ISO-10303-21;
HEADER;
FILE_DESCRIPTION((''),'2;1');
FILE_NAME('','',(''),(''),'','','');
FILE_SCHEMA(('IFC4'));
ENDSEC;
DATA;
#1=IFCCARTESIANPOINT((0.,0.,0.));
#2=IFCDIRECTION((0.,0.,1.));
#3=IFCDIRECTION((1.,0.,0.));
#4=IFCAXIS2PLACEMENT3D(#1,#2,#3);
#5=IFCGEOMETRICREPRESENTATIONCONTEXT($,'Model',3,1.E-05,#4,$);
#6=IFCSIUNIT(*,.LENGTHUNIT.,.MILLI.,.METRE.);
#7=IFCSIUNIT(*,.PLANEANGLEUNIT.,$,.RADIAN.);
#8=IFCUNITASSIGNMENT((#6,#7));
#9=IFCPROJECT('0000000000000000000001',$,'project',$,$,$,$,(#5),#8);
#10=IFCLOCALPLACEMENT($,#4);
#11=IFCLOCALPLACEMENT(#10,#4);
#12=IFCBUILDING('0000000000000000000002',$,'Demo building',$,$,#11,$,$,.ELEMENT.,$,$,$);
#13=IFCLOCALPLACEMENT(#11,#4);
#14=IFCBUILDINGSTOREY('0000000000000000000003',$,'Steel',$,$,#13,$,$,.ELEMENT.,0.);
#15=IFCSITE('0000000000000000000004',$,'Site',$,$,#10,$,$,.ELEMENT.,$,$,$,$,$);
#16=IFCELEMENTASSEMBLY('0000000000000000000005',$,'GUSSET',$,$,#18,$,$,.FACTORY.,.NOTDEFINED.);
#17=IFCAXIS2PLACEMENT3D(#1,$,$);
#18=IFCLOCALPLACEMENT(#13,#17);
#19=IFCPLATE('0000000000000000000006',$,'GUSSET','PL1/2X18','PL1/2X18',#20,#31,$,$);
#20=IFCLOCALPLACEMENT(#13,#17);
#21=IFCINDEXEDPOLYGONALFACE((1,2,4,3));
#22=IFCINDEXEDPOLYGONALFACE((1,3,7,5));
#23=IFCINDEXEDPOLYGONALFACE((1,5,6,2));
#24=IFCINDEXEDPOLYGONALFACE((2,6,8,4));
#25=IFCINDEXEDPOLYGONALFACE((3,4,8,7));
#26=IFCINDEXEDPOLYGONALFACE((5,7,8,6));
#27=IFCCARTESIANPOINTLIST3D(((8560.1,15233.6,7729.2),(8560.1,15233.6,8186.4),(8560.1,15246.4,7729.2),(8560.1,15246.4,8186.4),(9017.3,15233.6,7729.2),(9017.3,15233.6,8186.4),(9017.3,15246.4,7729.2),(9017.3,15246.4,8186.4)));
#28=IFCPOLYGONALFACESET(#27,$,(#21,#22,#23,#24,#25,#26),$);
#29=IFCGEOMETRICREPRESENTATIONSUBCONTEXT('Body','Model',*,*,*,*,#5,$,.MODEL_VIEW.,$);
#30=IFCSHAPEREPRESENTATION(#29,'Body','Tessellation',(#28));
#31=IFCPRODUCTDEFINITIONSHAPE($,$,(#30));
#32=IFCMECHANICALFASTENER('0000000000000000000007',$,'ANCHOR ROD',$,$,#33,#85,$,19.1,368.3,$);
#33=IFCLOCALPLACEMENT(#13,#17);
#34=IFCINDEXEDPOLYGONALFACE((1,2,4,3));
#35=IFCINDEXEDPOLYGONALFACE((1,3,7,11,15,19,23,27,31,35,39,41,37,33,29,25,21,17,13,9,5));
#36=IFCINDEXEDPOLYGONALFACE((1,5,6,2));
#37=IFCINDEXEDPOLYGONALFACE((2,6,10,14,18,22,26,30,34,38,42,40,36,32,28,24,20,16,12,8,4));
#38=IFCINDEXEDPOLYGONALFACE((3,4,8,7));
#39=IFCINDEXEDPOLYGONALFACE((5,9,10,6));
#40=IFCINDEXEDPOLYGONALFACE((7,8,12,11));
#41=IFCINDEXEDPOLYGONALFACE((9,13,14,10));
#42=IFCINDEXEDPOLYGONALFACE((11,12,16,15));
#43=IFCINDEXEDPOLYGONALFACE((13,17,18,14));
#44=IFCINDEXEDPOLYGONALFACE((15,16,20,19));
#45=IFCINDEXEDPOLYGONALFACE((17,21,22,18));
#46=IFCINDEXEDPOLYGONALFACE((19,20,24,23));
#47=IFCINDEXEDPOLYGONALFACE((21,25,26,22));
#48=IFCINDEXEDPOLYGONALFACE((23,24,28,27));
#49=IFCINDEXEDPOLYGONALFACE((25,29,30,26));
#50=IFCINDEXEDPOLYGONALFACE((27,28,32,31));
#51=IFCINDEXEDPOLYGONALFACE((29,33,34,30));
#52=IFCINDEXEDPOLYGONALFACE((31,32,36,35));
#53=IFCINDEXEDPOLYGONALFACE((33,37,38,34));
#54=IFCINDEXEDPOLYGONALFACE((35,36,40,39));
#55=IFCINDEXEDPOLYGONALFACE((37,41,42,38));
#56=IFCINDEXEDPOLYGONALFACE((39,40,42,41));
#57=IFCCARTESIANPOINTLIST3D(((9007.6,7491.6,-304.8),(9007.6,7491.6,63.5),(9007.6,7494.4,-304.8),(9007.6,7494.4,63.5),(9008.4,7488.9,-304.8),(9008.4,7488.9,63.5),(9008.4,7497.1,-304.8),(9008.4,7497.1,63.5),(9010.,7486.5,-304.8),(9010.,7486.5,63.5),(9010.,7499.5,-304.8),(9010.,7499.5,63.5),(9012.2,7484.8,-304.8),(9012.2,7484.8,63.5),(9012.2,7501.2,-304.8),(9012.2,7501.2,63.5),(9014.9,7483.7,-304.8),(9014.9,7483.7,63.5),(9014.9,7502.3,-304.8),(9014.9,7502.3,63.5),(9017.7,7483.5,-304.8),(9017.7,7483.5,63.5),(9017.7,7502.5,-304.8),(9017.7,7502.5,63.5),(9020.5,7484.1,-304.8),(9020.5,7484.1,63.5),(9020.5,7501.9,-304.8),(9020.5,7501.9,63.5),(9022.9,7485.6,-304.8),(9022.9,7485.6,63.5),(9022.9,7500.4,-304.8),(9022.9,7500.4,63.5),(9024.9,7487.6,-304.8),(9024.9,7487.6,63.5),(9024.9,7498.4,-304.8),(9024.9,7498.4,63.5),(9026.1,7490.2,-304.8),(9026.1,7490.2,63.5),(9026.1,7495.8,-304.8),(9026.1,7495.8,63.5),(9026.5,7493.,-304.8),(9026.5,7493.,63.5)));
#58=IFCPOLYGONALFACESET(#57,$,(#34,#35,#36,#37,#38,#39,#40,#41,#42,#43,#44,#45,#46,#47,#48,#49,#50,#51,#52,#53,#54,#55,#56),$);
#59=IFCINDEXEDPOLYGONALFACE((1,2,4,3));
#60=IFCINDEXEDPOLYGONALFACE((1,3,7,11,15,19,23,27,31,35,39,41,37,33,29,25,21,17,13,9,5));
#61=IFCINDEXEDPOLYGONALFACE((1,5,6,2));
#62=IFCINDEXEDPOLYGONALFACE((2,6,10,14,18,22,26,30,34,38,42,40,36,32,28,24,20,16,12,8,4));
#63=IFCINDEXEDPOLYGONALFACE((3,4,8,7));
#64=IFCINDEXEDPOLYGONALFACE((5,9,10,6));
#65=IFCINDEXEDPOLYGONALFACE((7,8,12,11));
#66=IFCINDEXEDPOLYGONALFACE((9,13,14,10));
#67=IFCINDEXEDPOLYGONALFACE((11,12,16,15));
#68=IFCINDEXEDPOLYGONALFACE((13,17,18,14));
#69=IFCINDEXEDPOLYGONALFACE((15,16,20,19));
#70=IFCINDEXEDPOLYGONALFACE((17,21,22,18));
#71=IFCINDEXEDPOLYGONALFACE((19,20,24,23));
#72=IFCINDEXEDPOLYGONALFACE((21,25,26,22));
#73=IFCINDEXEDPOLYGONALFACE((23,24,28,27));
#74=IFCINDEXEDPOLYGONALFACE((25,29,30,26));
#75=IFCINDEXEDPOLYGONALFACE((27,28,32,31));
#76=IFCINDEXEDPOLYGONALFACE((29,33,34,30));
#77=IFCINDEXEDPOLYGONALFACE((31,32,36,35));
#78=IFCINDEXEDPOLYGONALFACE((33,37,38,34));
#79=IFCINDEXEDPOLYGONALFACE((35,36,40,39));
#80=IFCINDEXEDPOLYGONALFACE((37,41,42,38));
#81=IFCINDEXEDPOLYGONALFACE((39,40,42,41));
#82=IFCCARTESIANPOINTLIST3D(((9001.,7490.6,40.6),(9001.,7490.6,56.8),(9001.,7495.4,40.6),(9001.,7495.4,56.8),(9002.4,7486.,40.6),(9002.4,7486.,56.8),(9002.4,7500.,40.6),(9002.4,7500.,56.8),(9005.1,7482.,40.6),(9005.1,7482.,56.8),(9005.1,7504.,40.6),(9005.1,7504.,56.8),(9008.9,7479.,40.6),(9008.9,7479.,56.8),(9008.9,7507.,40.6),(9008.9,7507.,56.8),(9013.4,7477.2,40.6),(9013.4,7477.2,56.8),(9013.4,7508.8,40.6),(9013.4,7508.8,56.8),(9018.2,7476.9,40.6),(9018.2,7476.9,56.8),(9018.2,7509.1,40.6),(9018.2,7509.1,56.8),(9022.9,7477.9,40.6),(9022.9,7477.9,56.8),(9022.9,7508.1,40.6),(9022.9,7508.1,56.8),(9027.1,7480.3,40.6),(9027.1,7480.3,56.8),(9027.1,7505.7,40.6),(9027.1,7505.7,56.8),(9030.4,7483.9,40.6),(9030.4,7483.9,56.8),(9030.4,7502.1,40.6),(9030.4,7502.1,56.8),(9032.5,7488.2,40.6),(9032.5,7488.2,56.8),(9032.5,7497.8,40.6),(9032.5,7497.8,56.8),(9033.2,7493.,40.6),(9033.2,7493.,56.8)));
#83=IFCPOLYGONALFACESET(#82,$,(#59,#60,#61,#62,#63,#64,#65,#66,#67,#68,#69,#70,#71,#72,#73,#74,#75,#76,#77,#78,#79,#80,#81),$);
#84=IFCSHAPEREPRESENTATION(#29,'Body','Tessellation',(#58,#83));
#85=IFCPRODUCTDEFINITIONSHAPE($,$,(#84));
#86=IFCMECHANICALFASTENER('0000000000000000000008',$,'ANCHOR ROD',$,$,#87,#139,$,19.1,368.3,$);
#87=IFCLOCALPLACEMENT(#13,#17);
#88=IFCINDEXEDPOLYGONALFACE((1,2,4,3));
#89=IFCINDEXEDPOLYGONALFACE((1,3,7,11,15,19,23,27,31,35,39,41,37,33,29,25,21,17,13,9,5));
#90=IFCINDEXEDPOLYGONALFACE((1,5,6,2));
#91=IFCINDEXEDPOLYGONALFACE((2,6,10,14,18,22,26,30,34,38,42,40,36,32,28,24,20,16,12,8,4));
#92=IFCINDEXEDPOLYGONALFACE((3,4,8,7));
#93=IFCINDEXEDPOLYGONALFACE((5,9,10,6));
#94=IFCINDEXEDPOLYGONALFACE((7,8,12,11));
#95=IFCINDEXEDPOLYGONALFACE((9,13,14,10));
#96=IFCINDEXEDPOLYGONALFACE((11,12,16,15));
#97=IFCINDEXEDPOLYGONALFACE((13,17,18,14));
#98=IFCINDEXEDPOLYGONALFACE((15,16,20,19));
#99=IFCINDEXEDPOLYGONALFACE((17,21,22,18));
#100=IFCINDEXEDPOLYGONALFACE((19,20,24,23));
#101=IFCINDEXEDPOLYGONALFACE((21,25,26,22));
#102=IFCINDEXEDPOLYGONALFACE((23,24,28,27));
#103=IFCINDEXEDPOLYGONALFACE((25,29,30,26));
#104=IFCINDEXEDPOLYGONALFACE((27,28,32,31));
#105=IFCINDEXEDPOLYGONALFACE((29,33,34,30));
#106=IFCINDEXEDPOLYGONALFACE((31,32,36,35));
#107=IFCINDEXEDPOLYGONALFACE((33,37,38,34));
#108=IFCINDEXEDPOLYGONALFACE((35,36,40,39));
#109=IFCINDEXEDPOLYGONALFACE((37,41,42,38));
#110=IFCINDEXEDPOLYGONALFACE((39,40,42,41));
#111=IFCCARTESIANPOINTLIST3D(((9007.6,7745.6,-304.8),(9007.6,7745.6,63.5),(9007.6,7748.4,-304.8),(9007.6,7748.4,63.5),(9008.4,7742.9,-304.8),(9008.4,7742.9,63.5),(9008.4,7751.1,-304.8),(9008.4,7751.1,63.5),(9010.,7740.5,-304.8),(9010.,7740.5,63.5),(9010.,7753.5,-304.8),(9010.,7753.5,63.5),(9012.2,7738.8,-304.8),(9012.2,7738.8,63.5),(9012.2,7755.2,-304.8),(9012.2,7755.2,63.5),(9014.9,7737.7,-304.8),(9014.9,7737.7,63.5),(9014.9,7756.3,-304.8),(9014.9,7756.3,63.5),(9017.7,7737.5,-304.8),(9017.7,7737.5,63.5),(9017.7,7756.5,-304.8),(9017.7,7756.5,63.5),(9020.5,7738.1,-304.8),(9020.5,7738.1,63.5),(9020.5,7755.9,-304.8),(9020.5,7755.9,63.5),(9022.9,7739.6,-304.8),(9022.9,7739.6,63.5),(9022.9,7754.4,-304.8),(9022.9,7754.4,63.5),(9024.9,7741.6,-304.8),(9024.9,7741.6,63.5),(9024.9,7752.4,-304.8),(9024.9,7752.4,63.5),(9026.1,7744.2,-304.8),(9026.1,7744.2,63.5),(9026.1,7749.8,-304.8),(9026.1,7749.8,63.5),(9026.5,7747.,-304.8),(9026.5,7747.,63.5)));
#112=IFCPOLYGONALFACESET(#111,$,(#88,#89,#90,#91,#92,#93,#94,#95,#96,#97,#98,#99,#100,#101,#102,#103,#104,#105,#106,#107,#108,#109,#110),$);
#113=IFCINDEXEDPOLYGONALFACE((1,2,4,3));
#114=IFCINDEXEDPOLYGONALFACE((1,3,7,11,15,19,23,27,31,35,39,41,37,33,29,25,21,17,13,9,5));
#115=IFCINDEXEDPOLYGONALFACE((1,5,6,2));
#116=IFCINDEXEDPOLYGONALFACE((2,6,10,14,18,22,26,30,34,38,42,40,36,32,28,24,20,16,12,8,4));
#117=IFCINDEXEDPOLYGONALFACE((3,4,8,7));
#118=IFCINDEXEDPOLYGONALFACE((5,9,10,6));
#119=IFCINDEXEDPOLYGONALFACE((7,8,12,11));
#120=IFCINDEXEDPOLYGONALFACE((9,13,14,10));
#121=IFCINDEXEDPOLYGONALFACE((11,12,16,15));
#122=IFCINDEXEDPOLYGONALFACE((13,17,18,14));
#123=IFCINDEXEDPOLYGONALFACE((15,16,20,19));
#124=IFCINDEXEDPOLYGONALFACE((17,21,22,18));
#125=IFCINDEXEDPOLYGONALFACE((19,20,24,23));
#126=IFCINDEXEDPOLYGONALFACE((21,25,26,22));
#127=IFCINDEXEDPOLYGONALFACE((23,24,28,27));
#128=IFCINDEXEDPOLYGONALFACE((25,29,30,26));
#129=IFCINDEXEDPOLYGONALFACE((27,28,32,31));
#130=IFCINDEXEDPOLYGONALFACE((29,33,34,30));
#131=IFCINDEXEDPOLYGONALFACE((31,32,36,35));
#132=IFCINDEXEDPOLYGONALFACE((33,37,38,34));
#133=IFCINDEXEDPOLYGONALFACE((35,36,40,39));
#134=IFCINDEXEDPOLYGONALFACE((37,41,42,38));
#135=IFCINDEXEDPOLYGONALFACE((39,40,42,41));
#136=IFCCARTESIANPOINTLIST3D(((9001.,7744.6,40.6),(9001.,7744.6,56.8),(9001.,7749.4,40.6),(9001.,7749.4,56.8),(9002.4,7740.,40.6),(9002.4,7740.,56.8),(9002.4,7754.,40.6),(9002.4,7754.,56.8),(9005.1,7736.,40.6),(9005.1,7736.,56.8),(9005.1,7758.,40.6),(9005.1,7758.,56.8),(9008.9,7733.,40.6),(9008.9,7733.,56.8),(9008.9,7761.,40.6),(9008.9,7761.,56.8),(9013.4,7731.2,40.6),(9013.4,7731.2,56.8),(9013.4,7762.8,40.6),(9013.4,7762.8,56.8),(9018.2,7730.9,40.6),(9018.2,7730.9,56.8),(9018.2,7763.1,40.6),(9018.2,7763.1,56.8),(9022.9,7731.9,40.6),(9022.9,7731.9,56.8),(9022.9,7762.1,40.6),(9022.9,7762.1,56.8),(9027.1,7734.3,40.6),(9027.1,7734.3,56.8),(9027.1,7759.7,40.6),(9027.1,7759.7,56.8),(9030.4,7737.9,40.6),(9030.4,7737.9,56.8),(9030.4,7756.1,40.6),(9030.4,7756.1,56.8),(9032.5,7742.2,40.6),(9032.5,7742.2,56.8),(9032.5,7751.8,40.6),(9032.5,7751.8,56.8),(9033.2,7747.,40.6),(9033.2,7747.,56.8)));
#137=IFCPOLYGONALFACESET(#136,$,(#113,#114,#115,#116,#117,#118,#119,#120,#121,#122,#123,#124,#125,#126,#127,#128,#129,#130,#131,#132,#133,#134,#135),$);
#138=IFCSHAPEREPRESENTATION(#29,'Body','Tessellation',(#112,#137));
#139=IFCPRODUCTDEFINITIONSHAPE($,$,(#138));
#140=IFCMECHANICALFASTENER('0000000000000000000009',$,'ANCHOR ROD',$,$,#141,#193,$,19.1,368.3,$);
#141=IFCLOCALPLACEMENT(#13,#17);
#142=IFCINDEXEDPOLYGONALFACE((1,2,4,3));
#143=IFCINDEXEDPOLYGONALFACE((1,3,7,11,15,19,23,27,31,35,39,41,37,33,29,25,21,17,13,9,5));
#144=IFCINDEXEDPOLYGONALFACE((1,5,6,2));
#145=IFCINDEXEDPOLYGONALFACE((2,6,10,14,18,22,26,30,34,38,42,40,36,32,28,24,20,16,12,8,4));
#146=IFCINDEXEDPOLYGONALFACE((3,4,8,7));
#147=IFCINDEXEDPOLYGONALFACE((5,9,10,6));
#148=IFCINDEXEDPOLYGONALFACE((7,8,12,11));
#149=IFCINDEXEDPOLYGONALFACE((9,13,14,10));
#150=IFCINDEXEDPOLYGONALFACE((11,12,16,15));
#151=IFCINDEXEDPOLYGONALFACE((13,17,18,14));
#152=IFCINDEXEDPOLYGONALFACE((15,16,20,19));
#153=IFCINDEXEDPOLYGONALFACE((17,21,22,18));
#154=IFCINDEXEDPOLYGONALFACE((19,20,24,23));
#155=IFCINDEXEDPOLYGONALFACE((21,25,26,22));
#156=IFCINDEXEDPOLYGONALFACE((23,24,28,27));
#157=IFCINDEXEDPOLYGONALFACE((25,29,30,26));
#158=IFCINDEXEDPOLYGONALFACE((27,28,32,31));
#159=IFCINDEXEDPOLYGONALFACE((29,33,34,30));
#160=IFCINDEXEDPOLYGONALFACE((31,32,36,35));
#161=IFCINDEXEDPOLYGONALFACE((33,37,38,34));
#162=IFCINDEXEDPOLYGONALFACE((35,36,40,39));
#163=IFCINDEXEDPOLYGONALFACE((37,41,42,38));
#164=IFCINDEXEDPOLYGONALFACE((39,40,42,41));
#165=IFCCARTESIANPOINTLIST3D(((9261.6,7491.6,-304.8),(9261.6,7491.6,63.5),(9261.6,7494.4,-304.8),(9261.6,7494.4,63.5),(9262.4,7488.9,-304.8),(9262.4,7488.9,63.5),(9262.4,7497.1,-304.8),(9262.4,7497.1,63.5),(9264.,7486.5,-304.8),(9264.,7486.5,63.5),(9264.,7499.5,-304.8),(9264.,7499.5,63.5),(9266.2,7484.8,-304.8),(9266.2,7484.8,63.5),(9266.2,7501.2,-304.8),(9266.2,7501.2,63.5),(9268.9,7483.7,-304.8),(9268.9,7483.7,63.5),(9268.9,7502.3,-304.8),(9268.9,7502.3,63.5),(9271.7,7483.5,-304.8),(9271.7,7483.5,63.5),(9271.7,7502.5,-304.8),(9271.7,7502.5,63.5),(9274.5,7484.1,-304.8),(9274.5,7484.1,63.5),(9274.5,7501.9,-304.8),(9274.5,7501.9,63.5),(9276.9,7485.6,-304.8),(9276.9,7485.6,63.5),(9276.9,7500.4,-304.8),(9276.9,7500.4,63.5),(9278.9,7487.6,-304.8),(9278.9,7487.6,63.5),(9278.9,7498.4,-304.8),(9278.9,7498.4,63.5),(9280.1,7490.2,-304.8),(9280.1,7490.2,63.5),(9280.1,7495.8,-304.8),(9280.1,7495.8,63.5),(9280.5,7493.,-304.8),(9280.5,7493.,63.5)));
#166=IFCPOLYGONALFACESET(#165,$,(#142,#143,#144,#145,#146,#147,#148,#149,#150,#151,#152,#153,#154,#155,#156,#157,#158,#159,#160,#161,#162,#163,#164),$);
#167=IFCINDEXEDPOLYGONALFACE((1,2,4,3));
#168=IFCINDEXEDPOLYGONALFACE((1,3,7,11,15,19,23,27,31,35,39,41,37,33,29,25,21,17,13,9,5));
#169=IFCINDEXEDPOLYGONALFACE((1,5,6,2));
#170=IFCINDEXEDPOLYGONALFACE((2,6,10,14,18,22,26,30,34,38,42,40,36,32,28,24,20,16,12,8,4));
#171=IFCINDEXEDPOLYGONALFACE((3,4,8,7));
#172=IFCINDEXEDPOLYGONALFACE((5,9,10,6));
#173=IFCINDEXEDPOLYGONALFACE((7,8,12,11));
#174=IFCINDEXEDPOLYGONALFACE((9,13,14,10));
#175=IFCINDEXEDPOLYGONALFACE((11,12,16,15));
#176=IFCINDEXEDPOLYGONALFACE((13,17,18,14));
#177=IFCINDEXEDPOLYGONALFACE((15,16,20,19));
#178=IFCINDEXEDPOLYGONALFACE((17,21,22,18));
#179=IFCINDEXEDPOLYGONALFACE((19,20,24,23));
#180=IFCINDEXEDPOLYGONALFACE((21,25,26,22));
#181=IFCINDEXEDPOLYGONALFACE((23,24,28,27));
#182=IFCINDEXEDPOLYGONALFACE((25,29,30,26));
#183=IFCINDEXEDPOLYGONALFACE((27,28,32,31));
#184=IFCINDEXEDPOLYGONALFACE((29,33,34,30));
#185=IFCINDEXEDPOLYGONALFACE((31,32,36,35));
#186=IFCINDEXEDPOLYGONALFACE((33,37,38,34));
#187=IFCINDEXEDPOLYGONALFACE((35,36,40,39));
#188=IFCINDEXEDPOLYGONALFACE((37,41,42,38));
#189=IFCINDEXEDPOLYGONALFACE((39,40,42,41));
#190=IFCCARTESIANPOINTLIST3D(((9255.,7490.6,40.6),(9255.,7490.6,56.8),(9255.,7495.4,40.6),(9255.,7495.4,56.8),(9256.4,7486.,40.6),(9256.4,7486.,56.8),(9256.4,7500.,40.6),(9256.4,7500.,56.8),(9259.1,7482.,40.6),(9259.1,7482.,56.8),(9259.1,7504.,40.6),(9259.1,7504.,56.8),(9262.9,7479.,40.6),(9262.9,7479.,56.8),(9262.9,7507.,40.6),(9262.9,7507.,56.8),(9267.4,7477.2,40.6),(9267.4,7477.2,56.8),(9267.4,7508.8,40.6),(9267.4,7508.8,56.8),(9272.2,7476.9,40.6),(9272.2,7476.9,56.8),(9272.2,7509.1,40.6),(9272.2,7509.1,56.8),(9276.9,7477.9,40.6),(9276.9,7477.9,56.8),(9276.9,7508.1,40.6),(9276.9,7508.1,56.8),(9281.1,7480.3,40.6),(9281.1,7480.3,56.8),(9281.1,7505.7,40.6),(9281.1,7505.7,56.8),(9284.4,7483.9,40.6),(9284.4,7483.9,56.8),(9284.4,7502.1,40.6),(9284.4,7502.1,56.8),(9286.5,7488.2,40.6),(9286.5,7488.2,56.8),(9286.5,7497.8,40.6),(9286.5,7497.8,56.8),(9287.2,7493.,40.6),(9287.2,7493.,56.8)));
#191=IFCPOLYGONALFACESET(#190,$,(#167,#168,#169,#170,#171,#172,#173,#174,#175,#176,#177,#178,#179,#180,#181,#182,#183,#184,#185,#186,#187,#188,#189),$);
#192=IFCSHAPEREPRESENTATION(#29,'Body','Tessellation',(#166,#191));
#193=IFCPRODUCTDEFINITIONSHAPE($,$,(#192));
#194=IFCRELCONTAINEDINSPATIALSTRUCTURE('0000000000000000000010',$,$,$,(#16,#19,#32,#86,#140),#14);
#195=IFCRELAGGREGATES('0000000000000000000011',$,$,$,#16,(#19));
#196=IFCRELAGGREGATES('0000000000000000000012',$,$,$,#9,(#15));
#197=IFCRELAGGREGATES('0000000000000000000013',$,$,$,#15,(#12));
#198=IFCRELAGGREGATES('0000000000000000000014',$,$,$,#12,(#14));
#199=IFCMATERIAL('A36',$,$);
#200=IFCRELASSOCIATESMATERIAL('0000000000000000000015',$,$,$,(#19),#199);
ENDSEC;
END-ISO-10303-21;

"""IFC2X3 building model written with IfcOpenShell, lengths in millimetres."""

from ifc_helpers import new_model, si_unit, frame, frame_2d, origin, origin_with_axes, origin_2d, place, context, subcontext, project, spatial, rectangle, circle, extrude, material, element, aggregate, save


model = new_model("IFC2X3")

# Units and contexts
model_context = context("Model", 3, precision=1e-05, world=origin_with_axes())
body_context = subcontext(model_context, "Body", "Model", "MODEL_VIEW")
ifc_project = project(units=[si_unit("LENGTHUNIT", "METRE", prefix="MILLI"), si_unit("PLANEANGLEUNIT", "RADIAN")], contexts=[model_context])

# Site, building, storey
site_placement = place(None, origin_with_axes())
site = spatial("IfcSite", under=ifc_project, at=site_placement, Name="Site", CompositionType="ELEMENT")
building_placement = place(site_placement, origin_with_axes())
building = spatial("IfcBuilding", under=site, at=building_placement, Name="Demo building", CompositionType="ELEMENT")
placement = place(building_placement, origin_with_axes())
storey = spatial("IfcBuildingStorey", under=building, at=placement, Name="Steel", CompositionType="ELEMENT", Elevation=0.0)

# Shared definitions
ifc_material_1 = material(Name="A36")

# Element assembly, plate
assembly_1 = element("IfcElementAssembly", 1, at=placement, inside=storey, Name="GUSSET", AssemblyPlace="FACTORY", PredefinedType="NOTDEFINED")
plate_1_placement = place(placement, frame((8560.1, 15246.4, 7729.2), z_axis=(0.0, -1.0, 0.0), x_axis=(1.0, 0.0, 0.0)))
plate_1 = element("IfcPlate", 2, at=plate_1_placement, inside=storey, material=ifc_material_1, Name="GUSSET", Description="PL1/2X18", ObjectType="PL1/2X18", context=body_context, shape_type="SweptSolid", body=[
    extrude(rectangle(XDim=457.2, YDim=457.2, at=frame_2d((228.6, 228.6))), origin(), (0.0, 0.0, 1.0), 12.7),
])
aggregate(assembly_1, [plate_1])

# Mechanical fasteners
for number, where, z_axis, x_axis, name in (
    (3, (9017.0, 7493.0, -304.8), (0.0, 0.0, 1.0), (1.0, 0.0, 0.0), "ANCHOR ROD"),
    (4, (9017.0, 7747.0, -304.8), (0.0, 0.0, 1.0), (1.0, 0.0, 0.0), "ANCHOR ROD"),
    (5, (9271.0, 7493.0, -304.8), (0.0, 0.0, 1.0), (1.0, 0.0, 0.0), "ANCHOR ROD"),
):
    element("IfcMechanicalFastener", number, at=place(placement, frame(where, z_axis=z_axis, x_axis=x_axis)), inside=storey, Name=name, NominalDiameter=19.1, NominalLength=368.3, context=body_context, shape_type="SweptSolid", body=[
        extrude(circle(Radius=9.5, at=origin_2d()), origin(), (0.0, 0.0, 1.0), 368.3),
        extrude(circle(Radius=16.2, at=origin_2d()), frame((0.0, 0.0, 345.4)), (0.0, 0.0, 1.0), 16.2),
    ])

save(model, "model.ifc")
